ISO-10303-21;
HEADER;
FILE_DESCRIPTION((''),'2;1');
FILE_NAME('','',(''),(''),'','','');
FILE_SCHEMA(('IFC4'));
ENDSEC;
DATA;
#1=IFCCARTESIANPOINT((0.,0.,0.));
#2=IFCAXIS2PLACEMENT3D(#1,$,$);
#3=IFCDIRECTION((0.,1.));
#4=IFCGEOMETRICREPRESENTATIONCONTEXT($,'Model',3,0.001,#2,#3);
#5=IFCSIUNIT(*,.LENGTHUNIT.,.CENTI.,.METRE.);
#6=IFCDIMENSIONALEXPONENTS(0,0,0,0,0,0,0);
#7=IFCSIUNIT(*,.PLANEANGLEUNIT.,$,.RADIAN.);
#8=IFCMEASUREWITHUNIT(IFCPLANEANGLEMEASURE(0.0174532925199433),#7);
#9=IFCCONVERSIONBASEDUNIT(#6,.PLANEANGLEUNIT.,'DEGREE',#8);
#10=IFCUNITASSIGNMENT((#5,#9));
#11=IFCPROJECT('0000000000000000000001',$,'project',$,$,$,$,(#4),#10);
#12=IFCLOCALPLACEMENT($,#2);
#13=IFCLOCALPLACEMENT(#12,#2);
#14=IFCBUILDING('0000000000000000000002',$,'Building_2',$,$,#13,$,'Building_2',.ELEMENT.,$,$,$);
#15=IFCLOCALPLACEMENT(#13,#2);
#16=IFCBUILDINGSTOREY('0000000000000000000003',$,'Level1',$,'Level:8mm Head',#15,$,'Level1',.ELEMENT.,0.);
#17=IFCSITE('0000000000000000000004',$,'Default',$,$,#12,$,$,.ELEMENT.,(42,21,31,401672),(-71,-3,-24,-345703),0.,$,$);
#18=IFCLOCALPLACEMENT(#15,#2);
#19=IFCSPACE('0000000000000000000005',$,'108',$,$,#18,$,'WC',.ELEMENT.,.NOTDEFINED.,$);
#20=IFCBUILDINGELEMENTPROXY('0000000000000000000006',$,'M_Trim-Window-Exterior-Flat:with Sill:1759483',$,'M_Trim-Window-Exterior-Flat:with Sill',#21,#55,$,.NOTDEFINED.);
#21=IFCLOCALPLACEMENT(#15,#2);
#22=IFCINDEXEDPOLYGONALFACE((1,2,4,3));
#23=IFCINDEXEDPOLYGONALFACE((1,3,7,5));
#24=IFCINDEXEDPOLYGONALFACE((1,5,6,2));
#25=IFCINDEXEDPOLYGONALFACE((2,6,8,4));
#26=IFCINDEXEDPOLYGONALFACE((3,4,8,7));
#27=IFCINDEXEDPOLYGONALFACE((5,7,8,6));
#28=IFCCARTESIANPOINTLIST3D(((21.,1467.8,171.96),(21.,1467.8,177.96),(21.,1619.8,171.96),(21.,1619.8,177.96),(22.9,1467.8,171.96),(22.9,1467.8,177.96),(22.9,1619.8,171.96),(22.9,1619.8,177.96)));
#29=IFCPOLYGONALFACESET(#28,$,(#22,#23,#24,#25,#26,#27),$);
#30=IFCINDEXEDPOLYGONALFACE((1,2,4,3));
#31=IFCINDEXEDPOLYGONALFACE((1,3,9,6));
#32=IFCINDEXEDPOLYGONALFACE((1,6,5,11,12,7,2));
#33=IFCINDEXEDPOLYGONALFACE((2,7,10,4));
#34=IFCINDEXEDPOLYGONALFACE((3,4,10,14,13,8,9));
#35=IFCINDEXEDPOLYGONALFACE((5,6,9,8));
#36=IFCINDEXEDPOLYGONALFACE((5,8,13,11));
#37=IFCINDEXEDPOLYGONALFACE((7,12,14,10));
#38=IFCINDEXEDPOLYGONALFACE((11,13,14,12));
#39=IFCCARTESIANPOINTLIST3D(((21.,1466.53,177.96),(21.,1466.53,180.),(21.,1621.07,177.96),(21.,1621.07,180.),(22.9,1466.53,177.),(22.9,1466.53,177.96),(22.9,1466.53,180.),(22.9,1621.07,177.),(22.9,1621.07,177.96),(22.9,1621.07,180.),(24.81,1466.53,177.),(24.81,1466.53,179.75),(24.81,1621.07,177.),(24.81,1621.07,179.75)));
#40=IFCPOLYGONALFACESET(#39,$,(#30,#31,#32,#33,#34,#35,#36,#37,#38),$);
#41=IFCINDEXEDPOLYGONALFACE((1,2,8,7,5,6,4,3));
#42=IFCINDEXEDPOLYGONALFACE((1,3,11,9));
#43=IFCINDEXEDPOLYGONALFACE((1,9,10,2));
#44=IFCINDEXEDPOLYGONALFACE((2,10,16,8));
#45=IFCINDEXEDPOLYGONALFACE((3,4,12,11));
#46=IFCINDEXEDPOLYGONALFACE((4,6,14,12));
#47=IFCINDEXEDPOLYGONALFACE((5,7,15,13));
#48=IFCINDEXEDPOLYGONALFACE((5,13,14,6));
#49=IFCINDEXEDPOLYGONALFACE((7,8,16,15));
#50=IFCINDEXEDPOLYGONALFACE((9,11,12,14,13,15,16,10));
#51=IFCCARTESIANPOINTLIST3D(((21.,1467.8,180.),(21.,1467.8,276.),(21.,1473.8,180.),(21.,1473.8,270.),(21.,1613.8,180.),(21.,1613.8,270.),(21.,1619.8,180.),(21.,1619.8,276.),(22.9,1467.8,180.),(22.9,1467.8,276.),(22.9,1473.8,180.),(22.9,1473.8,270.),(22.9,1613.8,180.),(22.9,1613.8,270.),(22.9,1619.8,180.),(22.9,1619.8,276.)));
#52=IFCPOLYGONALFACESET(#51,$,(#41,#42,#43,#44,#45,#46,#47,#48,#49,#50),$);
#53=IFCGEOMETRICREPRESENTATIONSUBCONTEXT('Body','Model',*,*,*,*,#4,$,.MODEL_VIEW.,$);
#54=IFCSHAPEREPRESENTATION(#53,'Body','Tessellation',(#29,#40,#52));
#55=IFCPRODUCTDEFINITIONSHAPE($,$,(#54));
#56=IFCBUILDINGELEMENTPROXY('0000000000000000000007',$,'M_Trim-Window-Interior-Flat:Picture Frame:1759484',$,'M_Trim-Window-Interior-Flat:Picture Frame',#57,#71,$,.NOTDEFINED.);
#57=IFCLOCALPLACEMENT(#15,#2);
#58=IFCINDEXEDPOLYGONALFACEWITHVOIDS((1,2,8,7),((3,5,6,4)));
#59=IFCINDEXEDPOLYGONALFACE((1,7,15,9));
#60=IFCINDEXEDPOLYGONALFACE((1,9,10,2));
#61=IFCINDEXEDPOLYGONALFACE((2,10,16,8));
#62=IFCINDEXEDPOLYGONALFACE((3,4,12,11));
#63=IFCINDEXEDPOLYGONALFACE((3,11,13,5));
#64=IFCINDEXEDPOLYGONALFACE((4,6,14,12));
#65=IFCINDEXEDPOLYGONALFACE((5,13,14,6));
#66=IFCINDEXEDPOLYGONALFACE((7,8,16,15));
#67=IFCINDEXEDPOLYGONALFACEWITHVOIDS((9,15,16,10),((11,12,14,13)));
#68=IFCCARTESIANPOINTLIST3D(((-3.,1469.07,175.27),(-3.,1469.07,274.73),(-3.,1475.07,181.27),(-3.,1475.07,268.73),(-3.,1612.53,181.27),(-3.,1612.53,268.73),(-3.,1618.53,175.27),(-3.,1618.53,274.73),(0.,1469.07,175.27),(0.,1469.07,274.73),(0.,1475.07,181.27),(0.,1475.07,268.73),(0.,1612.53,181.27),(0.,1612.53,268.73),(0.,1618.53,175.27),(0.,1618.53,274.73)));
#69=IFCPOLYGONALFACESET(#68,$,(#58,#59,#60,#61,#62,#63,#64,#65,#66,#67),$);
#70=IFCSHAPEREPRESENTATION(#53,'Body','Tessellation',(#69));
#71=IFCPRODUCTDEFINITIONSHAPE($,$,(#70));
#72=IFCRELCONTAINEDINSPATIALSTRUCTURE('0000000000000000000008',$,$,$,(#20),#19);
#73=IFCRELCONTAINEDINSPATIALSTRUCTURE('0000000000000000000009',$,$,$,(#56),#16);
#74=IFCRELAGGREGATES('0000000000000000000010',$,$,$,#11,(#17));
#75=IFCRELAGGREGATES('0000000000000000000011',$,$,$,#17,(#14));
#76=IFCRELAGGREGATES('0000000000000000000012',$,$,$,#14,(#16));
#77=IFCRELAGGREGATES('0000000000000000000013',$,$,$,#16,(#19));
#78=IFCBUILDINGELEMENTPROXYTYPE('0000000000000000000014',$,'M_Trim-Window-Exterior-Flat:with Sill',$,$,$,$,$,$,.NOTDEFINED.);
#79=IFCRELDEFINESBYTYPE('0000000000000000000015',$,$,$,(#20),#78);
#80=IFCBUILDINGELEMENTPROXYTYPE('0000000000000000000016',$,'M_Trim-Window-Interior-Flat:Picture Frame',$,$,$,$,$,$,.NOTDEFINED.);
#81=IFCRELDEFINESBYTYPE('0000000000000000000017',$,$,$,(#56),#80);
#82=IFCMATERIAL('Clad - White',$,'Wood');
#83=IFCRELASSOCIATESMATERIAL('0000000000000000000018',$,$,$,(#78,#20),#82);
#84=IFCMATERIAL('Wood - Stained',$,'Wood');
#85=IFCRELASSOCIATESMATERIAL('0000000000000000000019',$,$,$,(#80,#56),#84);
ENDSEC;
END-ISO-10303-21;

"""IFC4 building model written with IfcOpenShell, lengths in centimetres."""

from ifc_helpers import new_model, entity, si_unit, converted_unit, direction, frame, origin, place, context, subcontext, project, spatial, indexed_curve, outline, extrude, source, transform, mapped, material, type_object, type_shapes, element, save


model = new_model("IFC4")

# Units and contexts
model_context = context("Model", 3, precision=0.001, world=origin(), true_north=direction((0.0, 1.0)))
body_context = subcontext(model_context, "Body", "Model", "MODEL_VIEW")
ifc_project = project(units=[si_unit("LENGTHUNIT", "METRE", prefix="CENTI"), converted_unit("PLANEANGLEUNIT", "DEGREE", entity("IfcPlaneAngleMeasure", 0.0174532925199433), si_unit("PLANEANGLEUNIT", "RADIAN"), dimensions=[0, 0, 0, 0, 0, 0, 0])], contexts=[model_context])

# Site, building, storey
site_placement = place(None, origin())
site = spatial("IfcSite", under=ifc_project, at=site_placement, Name="Default", CompositionType="ELEMENT", RefLatitude=(42, 21, 31, 401672), RefLongitude=(-71, -3, -24, -345703), RefElevation=0.0)
building_placement = place(site_placement, origin())
building = spatial("IfcBuilding", under=site, at=building_placement, Name="Building_2", LongName="Building_2", CompositionType="ELEMENT")
storey_placement = place(building_placement, origin())
storey = spatial("IfcBuildingStorey", under=building, at=storey_placement, Name="Level1", ObjectType="Level:8mm Head", LongName="Level1", CompositionType="ELEMENT", Elevation=0.0)

# Shared definitions
ifc_material_1 = material(Name="Clad - White", Category="Wood")
ifc_material_2 = material(Name="Wood - Stained", Category="Wood")

# Shared definitions
space_1_placement = place(storey_placement, origin())
space_1 = spatial("IfcSpace", under=storey, at=space_1_placement, Name="108", LongName="WC", CompositionType="ELEMENT", PredefinedType="NOTDEFINED")

# Building element proxies
building_element_proxy_type_1 = type_object("IfcBuildingElementProxyType", Name="M_Trim-Window-Exterior-Flat:with Sill", PredefinedType="NOTDEFINED", material=ifc_material_1)
shared_shape_1 = source(origin(), body_context, "Body", "SweptSolid", [
    extrude(outline(indexed_curve([(-3.0, -76.0), (3.0, -76.0), (3.0, 76.0), (-3.0, 76.0), (-3.0, -76.0)], self_intersect=False)), frame((0.0, 95.04, 0.0), z_axis=(0.0, 0.0, 1.0), x_axis=(0.0, 1.0, 0.0)), (0.0, 0.0, 1.0), 1.91),
    extrude(outline(indexed_curve([(-1.52, -1.9), (1.23, -1.9), (1.48, 0.0), (1.48, 1.9), (-0.57, 1.9), (-0.57, 0.0), (-1.52, 0.0), (-1.52, -1.9)], self_intersect=False)), frame((-77.27, 91.48, 1.9), z_axis=(1.0, 0.0, 0.0), x_axis=(0.0, -1.0, 0.0)), (0.0, 0.0, 1.0), 154.54),
    extrude(outline(indexed_curve([(-76.0, -49.5), (76.0, -49.5), (76.0, 46.5), (70.0, 46.5), (70.0, -43.5), (-70.0, -43.5), (-70.0, 46.5), (-76.0, 46.5), (-76.0, -49.5)], self_intersect=False)), frame((0.0, 43.5, 0.0)), (0.0, 0.0, 1.0), 1.91),
])
type_shapes(building_element_proxy_type_1, [shared_shape_1])
proxy_1_placement = place(space_1_placement, frame((21.0, 1543.8, 270.0), z_axis=(1.0, 0.0, 0.0), x_axis=(0.0, -1.0, 0.0)))
element("IfcBuildingElementProxy", 1, at=proxy_1_placement, inside=space_1, type_object=building_element_proxy_type_1, material=ifc_material_1, Name="M_Trim-Window-Exterior-Flat:with Sill:1759483", ObjectType="M_Trim-Window-Exterior-Flat:with Sill", PredefinedType="NOTDEFINED", context=body_context, shape_type="MappedRepresentation", body=[
    mapped(shared_shape_1, transform((0.0, 0.0, 0.0), scale=1.0)),
])
building_element_proxy_type_2 = type_object("IfcBuildingElementProxyType", Name="M_Trim-Window-Interior-Flat:Picture Frame", PredefinedType="NOTDEFINED", material=ifc_material_2)
shared_shape_2 = source(origin(), body_context, "Body", "SweptSolid", [
    extrude(outline(indexed_curve([(-49.73, -74.73), (49.73, -74.73), (49.73, 74.73), (-49.73, 74.73), (-49.73, -74.73)], self_intersect=False), holes=[indexed_curve([(-43.73, -68.73), (-43.73, 68.73), (43.73, 68.73), (43.73, -68.73), (-43.73, -68.73)], self_intersect=False)]), frame((0.0, 45.0, 0.0), z_axis=(0.0, 0.0, 1.0), x_axis=(0.0, 1.0, 0.0)), (0.0, 0.0, 1.0), 3.0),
])
type_shapes(building_element_proxy_type_2, [shared_shape_2])
proxy_2_placement = place(storey_placement, frame((0.0, 1543.8, 270.0), z_axis=(-1.0, 0.0, 0.0), x_axis=(0.0, 1.0, 0.0)))
element("IfcBuildingElementProxy", 2, at=proxy_2_placement, inside=storey, type_object=building_element_proxy_type_2, material=ifc_material_2, Name="M_Trim-Window-Interior-Flat:Picture Frame:1759484", ObjectType="M_Trim-Window-Interior-Flat:Picture Frame", PredefinedType="NOTDEFINED", context=body_context, shape_type="MappedRepresentation", body=[
    mapped(shared_shape_2, transform((0.0, 0.0, 0.0), scale=1.0)),
])

save(model, "model.ifc")
